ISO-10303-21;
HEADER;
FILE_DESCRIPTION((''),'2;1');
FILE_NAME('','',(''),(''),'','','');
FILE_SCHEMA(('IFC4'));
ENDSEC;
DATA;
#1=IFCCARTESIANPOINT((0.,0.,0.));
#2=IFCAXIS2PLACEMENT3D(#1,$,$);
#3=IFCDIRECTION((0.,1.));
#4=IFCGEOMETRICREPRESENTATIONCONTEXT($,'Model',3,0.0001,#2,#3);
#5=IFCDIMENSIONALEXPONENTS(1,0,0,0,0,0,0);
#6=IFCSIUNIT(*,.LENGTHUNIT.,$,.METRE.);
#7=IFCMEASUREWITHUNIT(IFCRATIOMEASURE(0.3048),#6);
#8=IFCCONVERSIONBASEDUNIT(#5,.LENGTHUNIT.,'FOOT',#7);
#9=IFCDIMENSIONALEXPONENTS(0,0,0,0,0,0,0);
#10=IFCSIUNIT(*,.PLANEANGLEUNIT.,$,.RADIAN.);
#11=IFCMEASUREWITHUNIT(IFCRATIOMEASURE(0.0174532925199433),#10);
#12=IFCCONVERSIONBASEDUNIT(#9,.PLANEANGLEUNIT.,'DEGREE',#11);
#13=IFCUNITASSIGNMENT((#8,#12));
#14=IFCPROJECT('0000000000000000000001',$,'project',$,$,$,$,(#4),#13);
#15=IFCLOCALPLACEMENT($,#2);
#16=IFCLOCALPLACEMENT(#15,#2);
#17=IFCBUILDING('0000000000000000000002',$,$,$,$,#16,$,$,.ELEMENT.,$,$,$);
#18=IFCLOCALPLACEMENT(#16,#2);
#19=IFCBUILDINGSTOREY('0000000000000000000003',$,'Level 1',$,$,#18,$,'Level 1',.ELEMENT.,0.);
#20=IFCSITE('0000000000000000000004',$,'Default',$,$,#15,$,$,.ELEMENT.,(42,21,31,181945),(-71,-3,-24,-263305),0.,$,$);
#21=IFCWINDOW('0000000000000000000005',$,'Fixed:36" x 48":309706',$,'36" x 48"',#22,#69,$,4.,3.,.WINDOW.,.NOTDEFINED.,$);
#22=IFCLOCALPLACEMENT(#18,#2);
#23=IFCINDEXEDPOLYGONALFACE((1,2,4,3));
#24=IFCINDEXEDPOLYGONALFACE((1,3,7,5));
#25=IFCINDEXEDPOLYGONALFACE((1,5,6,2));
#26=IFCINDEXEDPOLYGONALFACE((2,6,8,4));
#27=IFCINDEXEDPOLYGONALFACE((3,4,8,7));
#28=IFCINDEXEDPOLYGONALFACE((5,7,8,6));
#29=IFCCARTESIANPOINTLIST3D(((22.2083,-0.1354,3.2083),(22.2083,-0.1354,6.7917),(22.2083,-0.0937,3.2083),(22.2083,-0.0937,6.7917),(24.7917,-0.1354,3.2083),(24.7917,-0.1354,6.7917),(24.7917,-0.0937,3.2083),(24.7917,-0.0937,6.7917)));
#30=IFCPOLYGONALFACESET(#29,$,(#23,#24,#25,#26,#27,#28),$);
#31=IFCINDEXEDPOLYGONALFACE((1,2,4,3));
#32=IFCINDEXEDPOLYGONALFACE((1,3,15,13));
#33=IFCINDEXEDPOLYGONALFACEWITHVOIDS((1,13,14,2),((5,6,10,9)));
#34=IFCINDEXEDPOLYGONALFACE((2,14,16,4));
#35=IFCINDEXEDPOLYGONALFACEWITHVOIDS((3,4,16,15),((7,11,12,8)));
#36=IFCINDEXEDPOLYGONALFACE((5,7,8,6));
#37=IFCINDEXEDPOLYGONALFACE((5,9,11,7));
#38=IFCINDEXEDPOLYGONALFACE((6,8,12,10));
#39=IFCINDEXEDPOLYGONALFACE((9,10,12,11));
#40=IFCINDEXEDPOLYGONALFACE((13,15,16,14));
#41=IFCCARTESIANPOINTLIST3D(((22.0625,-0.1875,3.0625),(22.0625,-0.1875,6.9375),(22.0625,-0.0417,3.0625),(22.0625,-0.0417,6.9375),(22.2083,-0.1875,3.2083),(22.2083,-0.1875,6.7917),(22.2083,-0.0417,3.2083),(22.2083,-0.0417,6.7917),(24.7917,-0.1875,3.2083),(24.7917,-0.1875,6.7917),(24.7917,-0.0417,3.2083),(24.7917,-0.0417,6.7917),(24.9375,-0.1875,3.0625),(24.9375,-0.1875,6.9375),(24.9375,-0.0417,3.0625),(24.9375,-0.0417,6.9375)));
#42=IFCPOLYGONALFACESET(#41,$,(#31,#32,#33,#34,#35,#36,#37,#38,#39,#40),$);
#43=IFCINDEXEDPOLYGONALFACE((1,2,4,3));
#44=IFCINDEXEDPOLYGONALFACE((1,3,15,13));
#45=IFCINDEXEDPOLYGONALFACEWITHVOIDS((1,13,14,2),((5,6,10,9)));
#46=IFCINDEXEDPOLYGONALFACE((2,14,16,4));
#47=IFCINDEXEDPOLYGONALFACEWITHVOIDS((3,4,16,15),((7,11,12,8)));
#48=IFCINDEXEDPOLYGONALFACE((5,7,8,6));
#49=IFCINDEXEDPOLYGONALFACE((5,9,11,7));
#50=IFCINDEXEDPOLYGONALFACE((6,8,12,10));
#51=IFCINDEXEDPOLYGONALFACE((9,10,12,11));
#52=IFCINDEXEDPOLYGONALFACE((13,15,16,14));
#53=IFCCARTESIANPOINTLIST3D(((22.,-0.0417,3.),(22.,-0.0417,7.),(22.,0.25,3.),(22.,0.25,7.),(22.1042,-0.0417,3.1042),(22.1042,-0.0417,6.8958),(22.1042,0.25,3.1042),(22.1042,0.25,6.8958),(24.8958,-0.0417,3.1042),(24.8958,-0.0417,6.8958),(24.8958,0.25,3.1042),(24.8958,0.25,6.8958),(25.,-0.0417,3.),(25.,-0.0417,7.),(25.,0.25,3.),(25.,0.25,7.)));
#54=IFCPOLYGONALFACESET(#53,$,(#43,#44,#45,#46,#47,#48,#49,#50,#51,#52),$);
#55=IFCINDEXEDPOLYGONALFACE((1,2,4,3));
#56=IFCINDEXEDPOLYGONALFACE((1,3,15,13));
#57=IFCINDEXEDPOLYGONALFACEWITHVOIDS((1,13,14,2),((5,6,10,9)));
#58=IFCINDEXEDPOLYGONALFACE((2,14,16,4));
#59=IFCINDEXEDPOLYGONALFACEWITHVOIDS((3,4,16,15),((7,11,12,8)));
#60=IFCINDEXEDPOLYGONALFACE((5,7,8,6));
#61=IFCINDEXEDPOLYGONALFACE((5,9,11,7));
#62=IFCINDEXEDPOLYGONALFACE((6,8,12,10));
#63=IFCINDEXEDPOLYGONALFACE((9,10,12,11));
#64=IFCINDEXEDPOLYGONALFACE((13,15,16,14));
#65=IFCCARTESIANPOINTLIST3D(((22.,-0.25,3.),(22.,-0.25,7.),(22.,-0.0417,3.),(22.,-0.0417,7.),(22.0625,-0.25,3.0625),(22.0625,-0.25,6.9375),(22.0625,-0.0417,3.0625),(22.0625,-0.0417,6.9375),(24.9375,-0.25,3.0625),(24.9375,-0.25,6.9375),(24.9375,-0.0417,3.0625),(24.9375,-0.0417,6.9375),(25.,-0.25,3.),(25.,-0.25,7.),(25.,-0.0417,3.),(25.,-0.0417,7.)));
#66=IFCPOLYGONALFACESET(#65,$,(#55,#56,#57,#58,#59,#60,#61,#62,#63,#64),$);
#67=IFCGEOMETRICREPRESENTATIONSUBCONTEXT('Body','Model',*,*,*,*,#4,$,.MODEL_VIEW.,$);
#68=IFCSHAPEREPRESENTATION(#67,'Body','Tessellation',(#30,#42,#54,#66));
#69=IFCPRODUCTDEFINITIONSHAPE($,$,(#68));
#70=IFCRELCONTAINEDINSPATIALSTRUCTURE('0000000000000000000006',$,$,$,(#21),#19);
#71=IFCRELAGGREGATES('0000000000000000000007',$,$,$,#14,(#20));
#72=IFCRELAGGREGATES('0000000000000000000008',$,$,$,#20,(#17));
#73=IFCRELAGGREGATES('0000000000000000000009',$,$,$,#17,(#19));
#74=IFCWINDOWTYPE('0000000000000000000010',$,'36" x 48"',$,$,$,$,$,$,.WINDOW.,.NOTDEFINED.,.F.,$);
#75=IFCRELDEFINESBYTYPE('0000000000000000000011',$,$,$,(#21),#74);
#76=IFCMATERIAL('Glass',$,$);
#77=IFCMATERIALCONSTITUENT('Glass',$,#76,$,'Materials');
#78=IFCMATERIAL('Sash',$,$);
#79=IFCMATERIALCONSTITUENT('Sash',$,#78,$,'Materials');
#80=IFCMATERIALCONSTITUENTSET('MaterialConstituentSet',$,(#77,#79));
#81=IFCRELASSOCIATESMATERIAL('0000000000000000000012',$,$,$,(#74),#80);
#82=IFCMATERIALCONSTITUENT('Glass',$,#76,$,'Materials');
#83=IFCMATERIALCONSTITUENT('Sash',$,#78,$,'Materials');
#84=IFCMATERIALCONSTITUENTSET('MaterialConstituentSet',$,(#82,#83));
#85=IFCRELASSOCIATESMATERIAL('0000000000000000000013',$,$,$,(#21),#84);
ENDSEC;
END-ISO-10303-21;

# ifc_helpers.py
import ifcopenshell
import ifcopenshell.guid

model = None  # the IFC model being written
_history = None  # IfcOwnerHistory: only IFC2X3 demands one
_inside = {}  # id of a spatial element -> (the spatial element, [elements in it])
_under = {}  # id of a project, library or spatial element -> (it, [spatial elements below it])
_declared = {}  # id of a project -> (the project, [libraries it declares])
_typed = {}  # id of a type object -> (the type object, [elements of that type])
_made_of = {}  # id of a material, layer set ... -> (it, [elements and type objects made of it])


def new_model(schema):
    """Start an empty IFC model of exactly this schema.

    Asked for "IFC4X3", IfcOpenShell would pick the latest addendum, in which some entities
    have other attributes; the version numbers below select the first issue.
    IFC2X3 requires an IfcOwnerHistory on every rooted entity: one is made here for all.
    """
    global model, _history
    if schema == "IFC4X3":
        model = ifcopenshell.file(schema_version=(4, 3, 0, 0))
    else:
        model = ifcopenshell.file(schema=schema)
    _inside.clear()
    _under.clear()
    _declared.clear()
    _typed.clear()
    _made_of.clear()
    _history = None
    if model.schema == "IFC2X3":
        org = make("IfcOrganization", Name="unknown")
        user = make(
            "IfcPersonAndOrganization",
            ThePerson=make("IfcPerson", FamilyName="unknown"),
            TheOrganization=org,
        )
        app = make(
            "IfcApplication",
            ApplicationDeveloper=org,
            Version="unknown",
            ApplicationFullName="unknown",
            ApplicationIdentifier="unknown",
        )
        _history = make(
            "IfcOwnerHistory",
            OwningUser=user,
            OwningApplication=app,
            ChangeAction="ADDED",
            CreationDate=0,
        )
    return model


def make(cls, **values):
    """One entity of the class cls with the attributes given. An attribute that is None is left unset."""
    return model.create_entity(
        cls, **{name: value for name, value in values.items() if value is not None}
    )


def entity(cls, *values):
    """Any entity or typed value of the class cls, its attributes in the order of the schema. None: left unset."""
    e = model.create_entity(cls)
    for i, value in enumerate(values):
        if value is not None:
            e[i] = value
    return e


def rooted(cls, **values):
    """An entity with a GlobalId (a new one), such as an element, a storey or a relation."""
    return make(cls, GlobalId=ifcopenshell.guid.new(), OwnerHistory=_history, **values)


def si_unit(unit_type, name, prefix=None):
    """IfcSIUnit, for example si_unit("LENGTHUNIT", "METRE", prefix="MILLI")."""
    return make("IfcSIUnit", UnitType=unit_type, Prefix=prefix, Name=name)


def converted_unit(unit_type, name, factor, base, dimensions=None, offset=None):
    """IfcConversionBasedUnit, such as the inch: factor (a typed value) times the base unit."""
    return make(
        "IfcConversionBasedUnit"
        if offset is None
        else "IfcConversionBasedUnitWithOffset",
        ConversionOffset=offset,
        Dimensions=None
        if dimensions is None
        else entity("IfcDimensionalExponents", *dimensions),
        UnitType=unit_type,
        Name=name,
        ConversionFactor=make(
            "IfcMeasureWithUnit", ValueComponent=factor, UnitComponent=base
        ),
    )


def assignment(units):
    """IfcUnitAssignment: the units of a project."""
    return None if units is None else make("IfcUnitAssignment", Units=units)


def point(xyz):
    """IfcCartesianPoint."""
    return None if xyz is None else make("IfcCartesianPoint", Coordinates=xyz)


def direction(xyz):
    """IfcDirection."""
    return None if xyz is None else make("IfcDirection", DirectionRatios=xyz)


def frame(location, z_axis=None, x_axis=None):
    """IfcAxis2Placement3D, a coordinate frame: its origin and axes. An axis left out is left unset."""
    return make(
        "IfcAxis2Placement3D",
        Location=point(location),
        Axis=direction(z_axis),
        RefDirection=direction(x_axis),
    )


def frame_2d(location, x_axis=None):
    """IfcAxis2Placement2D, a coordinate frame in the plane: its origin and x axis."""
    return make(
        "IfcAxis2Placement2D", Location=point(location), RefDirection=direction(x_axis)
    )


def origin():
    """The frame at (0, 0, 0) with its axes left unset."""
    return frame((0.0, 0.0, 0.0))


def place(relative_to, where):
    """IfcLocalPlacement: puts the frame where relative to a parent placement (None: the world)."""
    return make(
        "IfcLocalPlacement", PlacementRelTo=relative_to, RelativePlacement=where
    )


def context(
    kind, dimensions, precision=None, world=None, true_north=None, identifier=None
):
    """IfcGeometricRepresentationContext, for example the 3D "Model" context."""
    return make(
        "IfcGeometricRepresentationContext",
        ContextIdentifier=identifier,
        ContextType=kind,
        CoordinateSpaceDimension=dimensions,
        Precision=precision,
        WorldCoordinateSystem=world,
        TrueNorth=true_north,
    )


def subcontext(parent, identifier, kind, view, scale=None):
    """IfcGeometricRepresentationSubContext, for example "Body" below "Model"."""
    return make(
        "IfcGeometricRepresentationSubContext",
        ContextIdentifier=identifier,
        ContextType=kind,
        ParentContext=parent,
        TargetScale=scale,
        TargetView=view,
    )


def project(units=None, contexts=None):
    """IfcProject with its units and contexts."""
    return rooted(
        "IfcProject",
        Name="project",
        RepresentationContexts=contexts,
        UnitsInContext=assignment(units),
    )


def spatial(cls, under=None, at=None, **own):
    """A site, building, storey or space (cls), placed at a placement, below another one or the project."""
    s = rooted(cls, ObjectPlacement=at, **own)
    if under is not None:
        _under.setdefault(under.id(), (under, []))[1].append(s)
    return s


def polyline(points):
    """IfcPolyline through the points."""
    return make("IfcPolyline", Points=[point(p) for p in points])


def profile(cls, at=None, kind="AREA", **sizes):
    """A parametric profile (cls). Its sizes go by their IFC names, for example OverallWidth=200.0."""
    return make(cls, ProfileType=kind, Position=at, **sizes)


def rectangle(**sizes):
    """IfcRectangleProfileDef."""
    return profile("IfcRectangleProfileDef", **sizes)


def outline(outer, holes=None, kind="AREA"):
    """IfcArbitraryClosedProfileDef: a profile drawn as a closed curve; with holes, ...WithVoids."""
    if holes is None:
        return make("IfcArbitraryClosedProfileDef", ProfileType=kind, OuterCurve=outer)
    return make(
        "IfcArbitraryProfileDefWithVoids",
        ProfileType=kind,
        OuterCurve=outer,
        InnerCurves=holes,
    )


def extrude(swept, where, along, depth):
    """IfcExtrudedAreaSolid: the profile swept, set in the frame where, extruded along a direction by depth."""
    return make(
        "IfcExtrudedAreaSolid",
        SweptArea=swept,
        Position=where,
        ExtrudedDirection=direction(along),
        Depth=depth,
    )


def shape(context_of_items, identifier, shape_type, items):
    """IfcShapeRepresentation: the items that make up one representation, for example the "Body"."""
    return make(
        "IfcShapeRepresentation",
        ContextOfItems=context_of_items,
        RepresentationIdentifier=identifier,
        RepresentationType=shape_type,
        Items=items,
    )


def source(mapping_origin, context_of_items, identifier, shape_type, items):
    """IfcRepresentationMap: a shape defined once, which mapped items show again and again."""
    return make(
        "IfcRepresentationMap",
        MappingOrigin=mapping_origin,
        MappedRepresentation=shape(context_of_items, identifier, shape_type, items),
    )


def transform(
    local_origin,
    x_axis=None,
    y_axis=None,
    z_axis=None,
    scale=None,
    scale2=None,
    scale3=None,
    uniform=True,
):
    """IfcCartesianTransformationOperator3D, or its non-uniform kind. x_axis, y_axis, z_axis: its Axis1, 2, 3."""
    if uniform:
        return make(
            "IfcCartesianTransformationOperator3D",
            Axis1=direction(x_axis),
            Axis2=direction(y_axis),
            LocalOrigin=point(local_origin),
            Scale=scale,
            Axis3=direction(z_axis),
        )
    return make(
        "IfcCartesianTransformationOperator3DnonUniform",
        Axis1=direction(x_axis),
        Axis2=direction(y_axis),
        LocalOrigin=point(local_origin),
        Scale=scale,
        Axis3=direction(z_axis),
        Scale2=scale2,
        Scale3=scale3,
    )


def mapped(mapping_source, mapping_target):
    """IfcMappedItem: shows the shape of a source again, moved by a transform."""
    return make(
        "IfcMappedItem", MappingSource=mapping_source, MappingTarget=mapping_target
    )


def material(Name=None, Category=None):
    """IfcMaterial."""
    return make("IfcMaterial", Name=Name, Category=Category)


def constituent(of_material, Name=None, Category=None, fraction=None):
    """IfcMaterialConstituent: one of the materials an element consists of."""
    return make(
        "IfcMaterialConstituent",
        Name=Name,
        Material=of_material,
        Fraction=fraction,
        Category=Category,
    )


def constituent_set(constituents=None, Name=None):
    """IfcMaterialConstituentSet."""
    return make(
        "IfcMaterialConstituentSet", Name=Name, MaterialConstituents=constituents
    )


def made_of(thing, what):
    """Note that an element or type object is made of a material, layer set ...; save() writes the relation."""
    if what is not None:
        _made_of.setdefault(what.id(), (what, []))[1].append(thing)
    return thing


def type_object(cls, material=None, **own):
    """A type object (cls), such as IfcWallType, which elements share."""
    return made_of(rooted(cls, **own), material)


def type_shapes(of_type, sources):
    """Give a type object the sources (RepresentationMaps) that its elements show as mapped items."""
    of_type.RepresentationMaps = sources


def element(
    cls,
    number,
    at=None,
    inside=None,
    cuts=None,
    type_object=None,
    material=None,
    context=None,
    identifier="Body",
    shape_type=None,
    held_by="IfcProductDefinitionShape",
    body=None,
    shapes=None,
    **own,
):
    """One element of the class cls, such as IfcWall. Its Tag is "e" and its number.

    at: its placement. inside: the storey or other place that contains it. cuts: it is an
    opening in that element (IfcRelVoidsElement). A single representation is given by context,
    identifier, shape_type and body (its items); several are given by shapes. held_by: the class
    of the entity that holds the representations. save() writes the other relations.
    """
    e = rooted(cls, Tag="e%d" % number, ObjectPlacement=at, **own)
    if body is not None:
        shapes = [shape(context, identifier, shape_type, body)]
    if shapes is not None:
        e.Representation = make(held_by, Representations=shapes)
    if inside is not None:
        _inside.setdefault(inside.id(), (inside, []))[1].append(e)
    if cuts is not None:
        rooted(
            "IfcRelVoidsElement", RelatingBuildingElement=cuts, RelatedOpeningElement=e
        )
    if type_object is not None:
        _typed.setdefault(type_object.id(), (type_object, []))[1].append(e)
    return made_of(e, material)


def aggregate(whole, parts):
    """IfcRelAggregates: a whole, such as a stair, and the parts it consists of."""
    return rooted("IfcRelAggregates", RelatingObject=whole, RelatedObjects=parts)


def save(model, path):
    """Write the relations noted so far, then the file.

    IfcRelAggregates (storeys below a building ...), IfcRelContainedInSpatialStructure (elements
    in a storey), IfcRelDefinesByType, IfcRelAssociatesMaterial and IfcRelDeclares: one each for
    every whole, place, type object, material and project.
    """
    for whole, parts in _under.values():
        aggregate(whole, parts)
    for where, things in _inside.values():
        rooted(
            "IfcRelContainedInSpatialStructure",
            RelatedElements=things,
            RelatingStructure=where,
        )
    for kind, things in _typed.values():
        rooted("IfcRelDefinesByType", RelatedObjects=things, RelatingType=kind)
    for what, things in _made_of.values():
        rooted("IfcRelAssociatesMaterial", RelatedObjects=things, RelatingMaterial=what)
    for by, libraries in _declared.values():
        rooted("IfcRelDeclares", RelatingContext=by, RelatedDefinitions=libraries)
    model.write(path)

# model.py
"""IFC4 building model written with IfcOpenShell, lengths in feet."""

from ifc_helpers import new_model, entity, si_unit, converted_unit, direction, frame, frame_2d, origin, place, context, subcontext, project, spatial, polyline, rectangle, outline, extrude, source, transform, mapped, material, constituent, constituent_set, type_object, type_shapes, element, save


model = new_model("IFC4")

# Units and contexts
model_context = context("Model", 3, precision=0.0001, world=origin(), true_north=direction((0.0, 1.0)))
body_context = subcontext(model_context, "Body", "Model", "MODEL_VIEW")
ifc_project = project(units=[converted_unit("LENGTHUNIT", "FOOT", entity("IfcRatioMeasure", 0.3048), si_unit("LENGTHUNIT", "METRE"), dimensions=[1, 0, 0, 0, 0, 0, 0]), converted_unit("PLANEANGLEUNIT", "DEGREE", entity("IfcRatioMeasure", 0.0174532925199433), si_unit("PLANEANGLEUNIT", "RADIAN"), dimensions=[0, 0, 0, 0, 0, 0, 0])], contexts=[model_context])

# Site, building, storey
site_placement = place(None, origin())
site = spatial("IfcSite", under=ifc_project, at=site_placement, Name="Default", CompositionType="ELEMENT", RefLatitude=(42, 21, 31, 181945), RefLongitude=(-71, -3, -24, -263305), RefElevation=0.0)
building_placement = place(site_placement, origin())
building = spatial("IfcBuilding", under=site, at=building_placement, CompositionType="ELEMENT")
storey_placement = place(building_placement, origin())
storey = spatial("IfcBuildingStorey", under=building, at=storey_placement, Name="Level 1", LongName="Level 1", CompositionType="ELEMENT", Elevation=0.0)

# Shared definitions
placement_1 = place(storey_placement, frame((46.25, 0.0, 0.0), z_axis=(0.0, 0.0, 1.0), x_axis=(-1.0, 0.0, 0.0)))

# Window
ifc_material_1 = material(Name="Glass")
ifc_constituent_1 = constituent(ifc_material_1, Name="Glass", Category="Materials")
ifc_material_2 = material(Name="Sash")
ifc_constituent_2 = constituent(ifc_material_2, Name="Sash", Category="Materials")
ifc_constituent_set_1 = constituent_set(constituents=[ifc_constituent_1, ifc_constituent_2], Name="MaterialConstituentSet")
ifc_constituent_3 = constituent(ifc_material_1, Name="Glass", Category="Materials")
ifc_constituent_4 = constituent(ifc_material_2, Name="Sash", Category="Materials")
ifc_constituent_set_2 = constituent_set(constituents=[ifc_constituent_3, ifc_constituent_4], Name="MaterialConstituentSet")
window_type = type_object("IfcWindowType", Name="36\" x 48\"", ParameterTakesPrecedence=False, PartitioningType="NOTDEFINED", PredefinedType="WINDOW", material=ifc_constituent_set_2)
shared_shape = source(origin(), body_context, "Body", "SweptSolid", [
    extrude(rectangle(XDim=0.0417, YDim=2.5833, at=frame_2d((0.0, 0.0), x_axis=(1.0, 0.0))), frame((1.5, 0.3646, 0.2083), z_axis=(0.0, 0.0, 1.0), x_axis=(0.0, 1.0, 0.0)), (0.0, 0.0, 1.0), 3.5833),
    extrude(outline(polyline([(-1.4375, -1.9375), (1.4375, -1.9375), (1.4375, 1.9375), (-1.4375, 1.9375), (-1.4375, -1.9375)]), holes=[polyline([(-1.2917, -1.7917), (-1.2917, 1.7917), (1.2917, 1.7917), (1.2917, -1.7917), (-1.2917, -1.7917)])]), frame((1.5, 0.2917, 2.0), z_axis=(0.0, 1.0, 0.0), x_axis=(1.0, 0.0, 0.0)), (0.0, 0.0, 1.0), 0.1458),
    extrude(outline(polyline([(-1.5, -2.0), (1.5, -2.0), (1.5, 2.0), (-1.5, 2.0), (-1.5, -2.0)]), holes=[polyline([(-1.3958, -1.8958), (-1.3958, 1.8958), (1.3958, 1.8958), (1.3958, -1.8958), (-1.3958, -1.8958)])]), frame((1.5, 0.0, 2.0), z_axis=(0.0, 1.0, 0.0), x_axis=(1.0, 0.0, 0.0)), (0.0, 0.0, 1.0), 0.2917),
    extrude(outline(polyline([(-2.0, -1.5), (2.0, -1.5), (2.0, 1.5), (-2.0, 1.5), (-2.0, -1.5)]), holes=[polyline([(-1.9375, -1.4375), (-1.9375, 1.4375), (1.9375, 1.4375), (1.9375, -1.4375), (-1.9375, -1.4375)])]), frame((1.5, 0.2917, 2.0), z_axis=(0.0, 1.0, 0.0), x_axis=(0.0, 0.0, -1.0)), (0.0, 0.0, 1.0), 0.2083),
])
type_shapes(window_type, [shared_shape])
placement_2 = place(placement_1, frame((21.25, -0.25, 3.0)))
window_placement = place(placement_2, origin())
element("IfcWindow", 1, at=window_placement, inside=storey, type_object=window_type, material=ifc_constituent_set_1, Name="Fixed:36\" x 48\":309706", ObjectType="36\" x 48\"", OverallHeight=4.0, OverallWidth=3.0, PartitioningType="NOTDEFINED", PredefinedType="WINDOW", context=body_context, shape_type="MappedRepresentation", body=[
    mapped(shared_shape, transform((0.0, 0.0, 0.0), scale=1.0)),
])

save(model, "model.ifc")
